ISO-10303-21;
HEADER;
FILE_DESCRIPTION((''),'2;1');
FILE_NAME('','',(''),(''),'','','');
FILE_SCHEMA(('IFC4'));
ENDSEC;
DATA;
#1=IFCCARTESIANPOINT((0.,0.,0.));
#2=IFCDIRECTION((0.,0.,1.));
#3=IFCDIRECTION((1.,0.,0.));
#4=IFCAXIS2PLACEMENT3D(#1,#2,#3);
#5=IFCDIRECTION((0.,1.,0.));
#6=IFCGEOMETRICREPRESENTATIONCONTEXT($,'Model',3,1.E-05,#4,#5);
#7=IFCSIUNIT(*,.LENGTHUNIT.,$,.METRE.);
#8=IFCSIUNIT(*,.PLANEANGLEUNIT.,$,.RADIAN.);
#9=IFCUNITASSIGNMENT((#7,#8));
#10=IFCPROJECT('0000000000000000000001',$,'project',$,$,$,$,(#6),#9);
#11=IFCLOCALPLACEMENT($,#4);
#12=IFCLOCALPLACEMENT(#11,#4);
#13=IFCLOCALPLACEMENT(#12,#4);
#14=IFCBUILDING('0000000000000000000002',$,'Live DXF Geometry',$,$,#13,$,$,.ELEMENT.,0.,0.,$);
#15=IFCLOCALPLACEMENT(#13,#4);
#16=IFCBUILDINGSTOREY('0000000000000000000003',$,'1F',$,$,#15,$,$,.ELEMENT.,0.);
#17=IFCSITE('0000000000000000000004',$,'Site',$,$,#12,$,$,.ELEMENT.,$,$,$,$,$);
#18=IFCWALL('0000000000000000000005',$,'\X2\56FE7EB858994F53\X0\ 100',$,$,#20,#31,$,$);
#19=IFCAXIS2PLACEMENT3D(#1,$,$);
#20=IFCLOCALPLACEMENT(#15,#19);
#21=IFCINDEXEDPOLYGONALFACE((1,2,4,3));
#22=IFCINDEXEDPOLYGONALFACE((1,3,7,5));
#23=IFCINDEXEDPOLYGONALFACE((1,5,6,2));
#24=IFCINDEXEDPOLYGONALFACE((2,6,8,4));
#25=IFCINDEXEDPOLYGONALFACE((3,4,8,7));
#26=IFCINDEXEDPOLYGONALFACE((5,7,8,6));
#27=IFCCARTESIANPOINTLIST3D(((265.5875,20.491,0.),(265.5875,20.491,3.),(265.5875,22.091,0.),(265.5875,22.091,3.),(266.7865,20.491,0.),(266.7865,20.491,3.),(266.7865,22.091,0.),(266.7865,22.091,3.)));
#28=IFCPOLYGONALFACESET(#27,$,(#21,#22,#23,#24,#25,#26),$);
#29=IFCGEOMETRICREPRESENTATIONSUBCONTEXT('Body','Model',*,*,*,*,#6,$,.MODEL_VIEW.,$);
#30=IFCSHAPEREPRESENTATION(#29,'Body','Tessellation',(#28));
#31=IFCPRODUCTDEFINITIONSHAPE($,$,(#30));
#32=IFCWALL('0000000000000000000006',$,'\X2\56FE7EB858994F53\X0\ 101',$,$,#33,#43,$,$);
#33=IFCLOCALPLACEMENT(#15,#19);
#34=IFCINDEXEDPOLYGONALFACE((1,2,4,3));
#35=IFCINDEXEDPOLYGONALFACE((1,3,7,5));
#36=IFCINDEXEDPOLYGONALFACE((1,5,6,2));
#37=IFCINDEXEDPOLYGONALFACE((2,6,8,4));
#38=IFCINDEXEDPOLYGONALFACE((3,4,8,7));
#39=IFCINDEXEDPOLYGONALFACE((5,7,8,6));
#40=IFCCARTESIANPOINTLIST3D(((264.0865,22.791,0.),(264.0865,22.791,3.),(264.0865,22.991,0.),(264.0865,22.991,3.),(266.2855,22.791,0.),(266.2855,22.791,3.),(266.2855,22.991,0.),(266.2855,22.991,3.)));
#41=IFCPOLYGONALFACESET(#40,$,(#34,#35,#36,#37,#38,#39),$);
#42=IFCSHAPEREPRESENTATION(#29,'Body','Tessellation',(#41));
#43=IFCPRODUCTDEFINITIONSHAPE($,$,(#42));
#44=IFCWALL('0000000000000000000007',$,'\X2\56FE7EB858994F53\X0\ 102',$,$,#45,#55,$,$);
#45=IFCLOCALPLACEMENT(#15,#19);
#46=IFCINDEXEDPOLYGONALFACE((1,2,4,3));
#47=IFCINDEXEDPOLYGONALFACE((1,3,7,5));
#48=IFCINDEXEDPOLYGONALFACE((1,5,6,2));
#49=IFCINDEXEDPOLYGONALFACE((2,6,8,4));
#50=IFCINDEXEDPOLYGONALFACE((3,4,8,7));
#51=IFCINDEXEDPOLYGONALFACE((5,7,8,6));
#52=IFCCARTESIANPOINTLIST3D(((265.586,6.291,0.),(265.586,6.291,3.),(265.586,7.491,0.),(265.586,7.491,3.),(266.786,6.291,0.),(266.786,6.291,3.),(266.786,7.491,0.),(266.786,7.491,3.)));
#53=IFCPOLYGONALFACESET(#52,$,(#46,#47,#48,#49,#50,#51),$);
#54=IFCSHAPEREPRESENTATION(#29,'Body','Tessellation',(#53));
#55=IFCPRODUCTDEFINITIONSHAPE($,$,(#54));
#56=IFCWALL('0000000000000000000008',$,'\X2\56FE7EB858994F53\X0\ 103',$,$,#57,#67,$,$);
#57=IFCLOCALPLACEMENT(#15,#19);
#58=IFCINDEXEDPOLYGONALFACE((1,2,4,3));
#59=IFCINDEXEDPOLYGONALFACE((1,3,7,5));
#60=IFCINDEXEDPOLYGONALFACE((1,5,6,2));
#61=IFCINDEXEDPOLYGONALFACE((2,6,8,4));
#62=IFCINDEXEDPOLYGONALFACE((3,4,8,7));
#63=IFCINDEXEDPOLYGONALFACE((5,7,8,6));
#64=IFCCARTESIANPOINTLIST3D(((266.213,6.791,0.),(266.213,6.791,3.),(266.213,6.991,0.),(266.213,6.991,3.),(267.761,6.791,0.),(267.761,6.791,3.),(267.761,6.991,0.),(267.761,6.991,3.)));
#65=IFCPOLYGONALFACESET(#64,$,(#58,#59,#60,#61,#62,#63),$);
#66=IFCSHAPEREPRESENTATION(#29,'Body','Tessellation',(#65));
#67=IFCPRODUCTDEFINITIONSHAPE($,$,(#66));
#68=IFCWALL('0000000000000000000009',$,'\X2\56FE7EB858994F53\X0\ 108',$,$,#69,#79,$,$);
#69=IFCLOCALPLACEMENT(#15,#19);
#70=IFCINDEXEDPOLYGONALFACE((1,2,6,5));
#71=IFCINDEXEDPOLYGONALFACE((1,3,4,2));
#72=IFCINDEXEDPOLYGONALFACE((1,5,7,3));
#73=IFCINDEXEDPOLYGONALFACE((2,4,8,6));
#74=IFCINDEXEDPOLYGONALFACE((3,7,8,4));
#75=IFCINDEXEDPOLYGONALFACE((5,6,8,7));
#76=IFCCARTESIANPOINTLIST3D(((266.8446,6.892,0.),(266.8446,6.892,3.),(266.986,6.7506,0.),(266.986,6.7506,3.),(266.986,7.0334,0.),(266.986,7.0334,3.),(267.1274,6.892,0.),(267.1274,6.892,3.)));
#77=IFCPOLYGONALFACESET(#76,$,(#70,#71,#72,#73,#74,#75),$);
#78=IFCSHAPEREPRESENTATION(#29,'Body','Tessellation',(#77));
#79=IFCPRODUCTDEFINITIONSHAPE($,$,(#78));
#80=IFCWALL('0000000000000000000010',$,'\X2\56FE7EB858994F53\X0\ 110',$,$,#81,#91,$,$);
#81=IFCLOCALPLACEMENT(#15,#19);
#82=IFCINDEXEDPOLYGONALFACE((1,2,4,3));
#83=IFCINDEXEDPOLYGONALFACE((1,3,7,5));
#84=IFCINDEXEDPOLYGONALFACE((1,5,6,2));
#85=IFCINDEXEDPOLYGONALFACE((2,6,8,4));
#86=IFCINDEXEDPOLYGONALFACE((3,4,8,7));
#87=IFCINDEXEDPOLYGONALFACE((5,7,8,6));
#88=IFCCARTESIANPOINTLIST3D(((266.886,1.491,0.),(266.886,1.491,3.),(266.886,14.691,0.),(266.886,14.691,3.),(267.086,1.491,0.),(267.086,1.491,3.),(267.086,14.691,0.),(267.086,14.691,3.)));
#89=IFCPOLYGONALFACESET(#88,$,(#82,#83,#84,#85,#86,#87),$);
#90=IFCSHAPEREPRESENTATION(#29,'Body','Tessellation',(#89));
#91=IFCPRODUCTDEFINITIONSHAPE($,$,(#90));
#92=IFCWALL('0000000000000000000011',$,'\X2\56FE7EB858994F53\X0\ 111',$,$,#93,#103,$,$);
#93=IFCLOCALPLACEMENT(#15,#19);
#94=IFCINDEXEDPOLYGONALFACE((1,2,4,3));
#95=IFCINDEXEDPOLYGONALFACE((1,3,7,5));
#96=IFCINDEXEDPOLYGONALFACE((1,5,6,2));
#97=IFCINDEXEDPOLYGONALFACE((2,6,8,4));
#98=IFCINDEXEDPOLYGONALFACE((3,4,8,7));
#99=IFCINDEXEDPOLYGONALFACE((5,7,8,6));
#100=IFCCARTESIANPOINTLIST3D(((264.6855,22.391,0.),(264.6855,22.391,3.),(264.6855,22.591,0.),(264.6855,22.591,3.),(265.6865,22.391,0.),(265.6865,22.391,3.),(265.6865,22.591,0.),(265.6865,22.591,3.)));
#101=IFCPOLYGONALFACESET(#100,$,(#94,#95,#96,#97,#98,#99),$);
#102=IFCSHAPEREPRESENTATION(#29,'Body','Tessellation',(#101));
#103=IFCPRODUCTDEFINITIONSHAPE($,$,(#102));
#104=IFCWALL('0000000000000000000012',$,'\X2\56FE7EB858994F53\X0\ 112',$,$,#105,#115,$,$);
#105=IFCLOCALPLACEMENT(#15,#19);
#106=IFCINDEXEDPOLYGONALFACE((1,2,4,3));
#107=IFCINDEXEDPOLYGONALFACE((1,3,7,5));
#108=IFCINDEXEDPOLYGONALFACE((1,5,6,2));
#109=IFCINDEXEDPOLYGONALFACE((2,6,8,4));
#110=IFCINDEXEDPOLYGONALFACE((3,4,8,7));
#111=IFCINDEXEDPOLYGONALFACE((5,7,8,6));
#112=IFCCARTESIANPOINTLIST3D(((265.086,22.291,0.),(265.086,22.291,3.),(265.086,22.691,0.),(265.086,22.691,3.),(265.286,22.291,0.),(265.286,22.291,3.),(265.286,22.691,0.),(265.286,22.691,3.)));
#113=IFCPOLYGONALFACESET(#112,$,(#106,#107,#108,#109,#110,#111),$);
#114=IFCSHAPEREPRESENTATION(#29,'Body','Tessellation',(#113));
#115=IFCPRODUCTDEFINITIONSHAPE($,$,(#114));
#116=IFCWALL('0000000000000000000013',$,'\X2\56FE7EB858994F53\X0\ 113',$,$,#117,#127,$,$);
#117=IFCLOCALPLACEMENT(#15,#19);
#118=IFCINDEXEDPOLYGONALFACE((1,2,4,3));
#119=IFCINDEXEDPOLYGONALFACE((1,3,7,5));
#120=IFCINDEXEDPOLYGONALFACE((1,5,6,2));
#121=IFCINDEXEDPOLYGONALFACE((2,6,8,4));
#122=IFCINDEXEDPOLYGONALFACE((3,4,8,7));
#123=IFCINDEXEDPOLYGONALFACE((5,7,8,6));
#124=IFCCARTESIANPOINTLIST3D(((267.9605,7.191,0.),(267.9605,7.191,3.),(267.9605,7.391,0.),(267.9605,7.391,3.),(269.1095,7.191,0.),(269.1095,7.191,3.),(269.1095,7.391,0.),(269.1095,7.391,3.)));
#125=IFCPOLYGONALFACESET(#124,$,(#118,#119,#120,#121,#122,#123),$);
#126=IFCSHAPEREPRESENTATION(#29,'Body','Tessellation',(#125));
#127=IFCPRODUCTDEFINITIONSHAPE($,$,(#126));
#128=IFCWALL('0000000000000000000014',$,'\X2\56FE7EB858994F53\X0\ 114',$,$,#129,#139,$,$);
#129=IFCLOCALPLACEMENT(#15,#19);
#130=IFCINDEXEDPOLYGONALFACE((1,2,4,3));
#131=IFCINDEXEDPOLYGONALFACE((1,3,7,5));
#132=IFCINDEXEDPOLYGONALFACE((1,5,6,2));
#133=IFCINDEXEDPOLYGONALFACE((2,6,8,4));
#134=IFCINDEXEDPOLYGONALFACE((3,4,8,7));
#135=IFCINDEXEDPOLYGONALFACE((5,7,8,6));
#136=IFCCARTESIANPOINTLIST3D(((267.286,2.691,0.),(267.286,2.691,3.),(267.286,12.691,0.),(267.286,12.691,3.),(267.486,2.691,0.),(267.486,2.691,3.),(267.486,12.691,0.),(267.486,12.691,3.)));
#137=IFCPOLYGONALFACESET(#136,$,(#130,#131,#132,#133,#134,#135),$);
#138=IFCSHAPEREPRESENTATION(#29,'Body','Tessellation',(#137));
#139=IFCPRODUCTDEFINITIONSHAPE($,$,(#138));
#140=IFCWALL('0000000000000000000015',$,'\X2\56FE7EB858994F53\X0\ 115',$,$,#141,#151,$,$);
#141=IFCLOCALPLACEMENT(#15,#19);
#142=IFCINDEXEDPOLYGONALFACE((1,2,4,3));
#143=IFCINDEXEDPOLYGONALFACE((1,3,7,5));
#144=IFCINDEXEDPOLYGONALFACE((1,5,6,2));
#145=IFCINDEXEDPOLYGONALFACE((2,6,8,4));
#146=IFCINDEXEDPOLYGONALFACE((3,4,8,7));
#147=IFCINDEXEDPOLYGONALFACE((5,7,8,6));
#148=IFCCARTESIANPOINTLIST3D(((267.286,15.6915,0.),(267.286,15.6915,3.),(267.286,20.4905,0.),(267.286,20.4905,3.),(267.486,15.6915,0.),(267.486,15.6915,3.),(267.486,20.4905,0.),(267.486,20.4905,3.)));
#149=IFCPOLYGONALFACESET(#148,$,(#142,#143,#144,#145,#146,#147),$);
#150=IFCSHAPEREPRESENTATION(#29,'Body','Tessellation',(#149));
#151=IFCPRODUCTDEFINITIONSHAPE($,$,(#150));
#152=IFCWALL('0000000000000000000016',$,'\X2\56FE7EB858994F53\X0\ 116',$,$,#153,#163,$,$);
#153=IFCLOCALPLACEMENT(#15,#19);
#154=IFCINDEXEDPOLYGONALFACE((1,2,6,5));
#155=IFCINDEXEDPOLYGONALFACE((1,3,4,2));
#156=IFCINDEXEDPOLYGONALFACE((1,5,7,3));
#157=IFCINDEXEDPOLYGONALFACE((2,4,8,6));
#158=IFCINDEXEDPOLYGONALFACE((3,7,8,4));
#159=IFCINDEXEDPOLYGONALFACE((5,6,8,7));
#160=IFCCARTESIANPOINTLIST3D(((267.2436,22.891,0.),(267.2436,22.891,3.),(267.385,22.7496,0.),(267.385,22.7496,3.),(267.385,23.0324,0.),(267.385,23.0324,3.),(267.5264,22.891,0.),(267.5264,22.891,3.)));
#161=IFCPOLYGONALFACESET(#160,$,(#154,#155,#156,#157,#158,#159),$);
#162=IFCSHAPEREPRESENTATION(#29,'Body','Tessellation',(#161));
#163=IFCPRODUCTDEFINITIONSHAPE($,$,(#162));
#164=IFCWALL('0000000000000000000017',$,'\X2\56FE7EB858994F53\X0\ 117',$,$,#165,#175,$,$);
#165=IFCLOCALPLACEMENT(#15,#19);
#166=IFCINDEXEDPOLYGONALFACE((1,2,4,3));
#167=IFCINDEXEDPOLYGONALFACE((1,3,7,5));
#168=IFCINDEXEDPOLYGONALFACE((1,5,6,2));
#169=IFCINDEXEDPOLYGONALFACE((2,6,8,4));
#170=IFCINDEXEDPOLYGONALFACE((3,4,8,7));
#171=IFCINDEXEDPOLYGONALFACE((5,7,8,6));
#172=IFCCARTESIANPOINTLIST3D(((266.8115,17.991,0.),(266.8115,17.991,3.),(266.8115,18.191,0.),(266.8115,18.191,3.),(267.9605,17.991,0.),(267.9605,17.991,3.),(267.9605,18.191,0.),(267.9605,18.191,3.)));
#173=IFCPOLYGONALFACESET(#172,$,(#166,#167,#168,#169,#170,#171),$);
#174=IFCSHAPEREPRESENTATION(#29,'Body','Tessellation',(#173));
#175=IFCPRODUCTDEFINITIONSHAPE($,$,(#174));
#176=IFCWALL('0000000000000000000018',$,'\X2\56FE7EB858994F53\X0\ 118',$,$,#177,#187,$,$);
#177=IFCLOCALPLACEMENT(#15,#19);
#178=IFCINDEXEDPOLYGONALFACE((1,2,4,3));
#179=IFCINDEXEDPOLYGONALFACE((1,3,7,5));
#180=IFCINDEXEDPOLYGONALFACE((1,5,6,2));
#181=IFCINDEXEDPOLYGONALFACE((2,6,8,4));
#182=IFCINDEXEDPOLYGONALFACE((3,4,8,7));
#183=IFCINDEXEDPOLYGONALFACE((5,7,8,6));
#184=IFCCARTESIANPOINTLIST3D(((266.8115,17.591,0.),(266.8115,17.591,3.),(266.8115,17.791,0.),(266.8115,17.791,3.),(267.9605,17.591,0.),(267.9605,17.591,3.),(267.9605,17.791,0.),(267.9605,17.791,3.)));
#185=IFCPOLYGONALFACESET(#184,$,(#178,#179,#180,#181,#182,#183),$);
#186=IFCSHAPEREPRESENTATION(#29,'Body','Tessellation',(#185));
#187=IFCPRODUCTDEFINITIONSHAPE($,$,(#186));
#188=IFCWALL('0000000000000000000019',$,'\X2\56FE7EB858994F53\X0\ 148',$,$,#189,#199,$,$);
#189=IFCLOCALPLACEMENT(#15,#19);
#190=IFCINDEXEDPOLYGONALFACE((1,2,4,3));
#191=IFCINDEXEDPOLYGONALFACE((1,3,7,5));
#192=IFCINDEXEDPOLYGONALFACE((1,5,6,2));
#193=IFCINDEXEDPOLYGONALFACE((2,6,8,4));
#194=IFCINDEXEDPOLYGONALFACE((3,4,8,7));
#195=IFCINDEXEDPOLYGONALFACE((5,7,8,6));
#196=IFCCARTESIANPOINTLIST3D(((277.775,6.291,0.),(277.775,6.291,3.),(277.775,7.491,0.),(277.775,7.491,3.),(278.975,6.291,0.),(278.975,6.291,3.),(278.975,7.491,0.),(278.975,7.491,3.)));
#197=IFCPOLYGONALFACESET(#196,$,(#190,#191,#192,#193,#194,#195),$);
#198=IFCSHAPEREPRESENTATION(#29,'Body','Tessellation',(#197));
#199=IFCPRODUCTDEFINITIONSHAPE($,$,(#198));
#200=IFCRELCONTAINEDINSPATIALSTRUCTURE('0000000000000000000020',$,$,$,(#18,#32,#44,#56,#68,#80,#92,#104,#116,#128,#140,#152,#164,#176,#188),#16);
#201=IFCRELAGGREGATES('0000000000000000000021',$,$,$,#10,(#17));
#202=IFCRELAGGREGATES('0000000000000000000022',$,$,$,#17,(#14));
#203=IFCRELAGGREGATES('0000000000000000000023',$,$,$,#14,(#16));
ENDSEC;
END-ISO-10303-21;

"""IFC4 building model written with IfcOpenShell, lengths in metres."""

from ifc_helpers import new_model, si_unit, direction, frame, frame_2d, origin_with_axes, place, context, subcontext, project, spatial, rectangle, extrude, element, save


model = new_model("IFC4")

# Units and contexts
model_context = context("Model", 3, precision=1e-05, world=origin_with_axes(), true_north=direction((0.0, 1.0, 0.0)))
body_context = subcontext(model_context, "Body", "Model", "MODEL_VIEW")
ifc_project = project(units=[si_unit("LENGTHUNIT", "METRE"), si_unit("PLANEANGLEUNIT", "RADIAN")], contexts=[model_context])

# Site, building, storey
placement = place(None, origin_with_axes())
site_placement = place(placement, origin_with_axes())
site = spatial("IfcSite", under=ifc_project, at=site_placement, Name="Site", CompositionType="ELEMENT")
building_placement = place(site_placement, origin_with_axes())
building = spatial("IfcBuilding", under=site, at=building_placement, Name="Live DXF Geometry", CompositionType="ELEMENT", ElevationOfRefHeight=0.0, ElevationOfTerrain=0.0)
storey_placement = place(building_placement, origin_with_axes())
storey = spatial("IfcBuildingStorey", under=building, at=storey_placement, Name="1F", CompositionType="ELEMENT", Elevation=0.0)

# Walls
wall_1_placement = place(storey_placement, frame((266.187, 21.291, 0.0), z_axis=(0.0, 0.0, 1.0), x_axis=(1.0, 0.0, 0.0)))
element("IfcWall", 1, at=wall_1_placement, inside=storey, Name="图纸墙体 100", context=body_context, shape_type="SweptSolid", body=[
    extrude(rectangle(XDim=1.199, YDim=1.6, at=frame_2d((0.0, 0.0), x_axis=(1.0, 0.0, 0.0))), frame((0.0, 0.0, 0.0), z_axis=(0.0, 0.0, 1.0)), (0.0, 0.0, 1.0), 3.0),
])
wall_2_placement = place(storey_placement, frame((265.186, 22.891, 0.0), z_axis=(0.0, 0.0, 1.0), x_axis=(1.0, 0.0, 0.0)))
element("IfcWall", 2, at=wall_2_placement, inside=storey, Name="图纸墙体 101", context=body_context, shape_type="SweptSolid", body=[
    extrude(rectangle(XDim=2.199, YDim=0.2, at=frame_2d((0.0, 0.0), x_axis=(1.0, 0.0, 0.0))), frame((0.0, 0.0, 0.0), z_axis=(0.0, 0.0, 1.0)), (0.0, 0.0, 1.0), 3.0),
])
wall_3_placement = place(storey_placement, frame((266.186, 6.891, 0.0), z_axis=(0.0, 0.0, 1.0), x_axis=(1.0, 0.0, 0.0)))
element("IfcWall", 3, at=wall_3_placement, inside=storey, Name="图纸墙体 102", context=body_context, shape_type="SweptSolid", body=[
    extrude(rectangle(XDim=1.2, YDim=1.2, at=frame_2d((0.0, 0.0), x_axis=(1.0, 0.0, 0.0))), frame((0.0, 0.0, 0.0), z_axis=(0.0, 0.0, 1.0)), (0.0, 0.0, 1.0), 3.0),
])
wall_4_placement = place(storey_placement, frame((266.987, 6.891, 0.0), z_axis=(0.0, 0.0, 1.0), x_axis=(1.0, 0.0, 0.0)))
element("IfcWall", 4, at=wall_4_placement, inside=storey, Name="图纸墙体 103", context=body_context, shape_type="SweptSolid", body=[
    extrude(rectangle(XDim=1.548, YDim=0.2, at=frame_2d((0.0, 0.0), x_axis=(1.0, 0.0, 0.0))), frame((0.0, 0.0, 0.0), z_axis=(0.0, 0.0, 1.0)), (0.0, 0.0, 1.0), 3.0),
])
wall_5_placement = place(storey_placement, frame((266.986, 6.892, 0.0), z_axis=(0.0, 0.0, 1.0), x_axis=(0.707107, -0.707107, 0.0)))
element("IfcWall", 5, at=wall_5_placement, inside=storey, Name="图纸墙体 108", context=body_context, shape_type="SweptSolid", body=[
    extrude(rectangle(XDim=0.2, YDim=0.2, at=frame_2d((0.0, 0.0), x_axis=(1.0, 0.0, 0.0))), frame((0.0, 0.0, 0.0), z_axis=(0.0, 0.0, 1.0)), (0.0, 0.0, 1.0), 3.0),
])
wall_6_placement = place(storey_placement, frame((266.986, 8.091, 0.0), z_axis=(0.0, 0.0, 1.0), x_axis=(0.0, 1.0, 0.0)))
element("IfcWall", 6, at=wall_6_placement, inside=storey, Name="图纸墙体 110", context=body_context, shape_type="SweptSolid", body=[
    extrude(rectangle(XDim=13.2, YDim=0.2, at=frame_2d((0.0, 0.0), x_axis=(1.0, 0.0, 0.0))), frame((0.0, 0.0, 0.0), z_axis=(0.0, 0.0, 1.0)), (0.0, 0.0, 1.0), 3.0),
])
wall_7_placement = place(storey_placement, frame((265.186, 22.491, 0.0), z_axis=(0.0, 0.0, 1.0), x_axis=(1.0, 0.0, 0.0)))
element("IfcWall", 7, at=wall_7_placement, inside=storey, Name="图纸墙体 111", context=body_context, shape_type="SweptSolid", body=[
    extrude(rectangle(XDim=1.001, YDim=0.2, at=frame_2d((0.0, 0.0), x_axis=(1.0, 0.0, 0.0))), frame((0.0, 0.0, 0.0), z_axis=(0.0, 0.0, 1.0)), (0.0, 0.0, 1.0), 3.0),
])
wall_8_placement = place(storey_placement, frame((265.186, 22.491, 0.0), z_axis=(0.0, 0.0, 1.0), x_axis=(0.0, 1.0, 0.0)))
element("IfcWall", 8, at=wall_8_placement, inside=storey, Name="图纸墙体 112", context=body_context, shape_type="SweptSolid", body=[
    extrude(rectangle(XDim=0.4, YDim=0.2, at=frame_2d((0.0, 0.0), x_axis=(1.0, 0.0, 0.0))), frame((0.0, 0.0, 0.0), z_axis=(0.0, 0.0, 1.0)), (0.0, 0.0, 1.0), 3.0),
])
wall_9_placement = place(storey_placement, frame((268.535, 7.291, 0.0), z_axis=(0.0, 0.0, 1.0), x_axis=(-1.0, 0.0, 0.0)))
element("IfcWall", 9, at=wall_9_placement, inside=storey, Name="图纸墙体 113", context=body_context, shape_type="SweptSolid", body=[
    extrude(rectangle(XDim=1.149, YDim=0.2, at=frame_2d((0.0, 0.0), x_axis=(1.0, 0.0, 0.0))), frame((0.0, 0.0, 0.0), z_axis=(0.0, 0.0, 1.0)), (0.0, 0.0, 1.0), 3.0),
])
wall_10_placement = place(storey_placement, frame((267.386, 7.691, 0.0), z_axis=(0.0, 0.0, 1.0), x_axis=(0.0, 1.0, 0.0)))
element("IfcWall", 10, at=wall_10_placement, inside=storey, Name="图纸墙体 114", context=body_context, shape_type="SweptSolid", body=[
    extrude(rectangle(XDim=10.0, YDim=0.2, at=frame_2d((0.0, 0.0), x_axis=(1.0, 0.0, 0.0))), frame((0.0, 0.0, 0.0), z_axis=(0.0, 0.0, 1.0)), (0.0, 0.0, 1.0), 3.0),
])
wall_11_placement = place(storey_placement, frame((267.386, 18.091, 0.0), z_axis=(0.0, 0.0, 1.0), x_axis=(0.0, 1.0, 0.0)))
element("IfcWall", 11, at=wall_11_placement, inside=storey, Name="图纸墙体 115", context=body_context, shape_type="SweptSolid", body=[
    extrude(rectangle(XDim=4.799, YDim=0.2, at=frame_2d((0.0, 0.0), x_axis=(1.0, 0.0, 0.0))), frame((0.0, 0.0, 0.0), z_axis=(0.0, 0.0, 1.0)), (0.0, 0.0, 1.0), 3.0),
])
wall_12_placement = place(storey_placement, frame((267.385, 22.891, 0.0), z_axis=(0.0, 0.0, 1.0), x_axis=(0.707107, -0.707107, 0.0)))
element("IfcWall", 12, at=wall_12_placement, inside=storey, Name="图纸墙体 116", context=body_context, shape_type="SweptSolid", body=[
    extrude(rectangle(XDim=0.2, YDim=0.2, at=frame_2d((0.0, 0.0), x_axis=(1.0, 0.0, 0.0))), frame((0.0, 0.0, 0.0), z_axis=(0.0, 0.0, 1.0)), (0.0, 0.0, 1.0), 3.0),
])
for number, where, z_axis, x_axis, name in (
    (13, (267.386, 18.091, 0.0), (0.0, 0.0, 1.0), (1.0, 0.0, 0.0), "图纸墙体 117"),
    (14, (267.386, 17.691, 0.0), (0.0, 0.0, 1.0), (1.0, 0.0, 0.0), "图纸墙体 118"),
):
    element("IfcWall", number, at=place(storey_placement, frame(where, z_axis=z_axis, x_axis=x_axis)), inside=storey, Name=name, context=body_context, shape_type="SweptSolid", body=[
        extrude(rectangle(XDim=1.149, YDim=0.2, at=frame_2d((0.0, 0.0), x_axis=(1.0, 0.0, 0.0))), frame((0.0, 0.0, 0.0), z_axis=(0.0, 0.0, 1.0)), (0.0, 0.0, 1.0), 3.0),
    ])
wall_13_placement = place(storey_placement, frame((278.375, 6.891, 0.0), z_axis=(0.0, 0.0, 1.0), x_axis=(1.0, 0.0, 0.0)))
element("IfcWall", 15, at=wall_13_placement, inside=storey, Name="图纸墙体 148", context=body_context, shape_type="SweptSolid", body=[
    extrude(rectangle(XDim=1.2, YDim=1.2, at=frame_2d((0.0, 0.0), x_axis=(1.0, 0.0, 0.0))), frame((0.0, 0.0, 0.0), z_axis=(0.0, 0.0, 1.0)), (0.0, 0.0, 1.0), 3.0),
])

save(model, "model.ifc")
